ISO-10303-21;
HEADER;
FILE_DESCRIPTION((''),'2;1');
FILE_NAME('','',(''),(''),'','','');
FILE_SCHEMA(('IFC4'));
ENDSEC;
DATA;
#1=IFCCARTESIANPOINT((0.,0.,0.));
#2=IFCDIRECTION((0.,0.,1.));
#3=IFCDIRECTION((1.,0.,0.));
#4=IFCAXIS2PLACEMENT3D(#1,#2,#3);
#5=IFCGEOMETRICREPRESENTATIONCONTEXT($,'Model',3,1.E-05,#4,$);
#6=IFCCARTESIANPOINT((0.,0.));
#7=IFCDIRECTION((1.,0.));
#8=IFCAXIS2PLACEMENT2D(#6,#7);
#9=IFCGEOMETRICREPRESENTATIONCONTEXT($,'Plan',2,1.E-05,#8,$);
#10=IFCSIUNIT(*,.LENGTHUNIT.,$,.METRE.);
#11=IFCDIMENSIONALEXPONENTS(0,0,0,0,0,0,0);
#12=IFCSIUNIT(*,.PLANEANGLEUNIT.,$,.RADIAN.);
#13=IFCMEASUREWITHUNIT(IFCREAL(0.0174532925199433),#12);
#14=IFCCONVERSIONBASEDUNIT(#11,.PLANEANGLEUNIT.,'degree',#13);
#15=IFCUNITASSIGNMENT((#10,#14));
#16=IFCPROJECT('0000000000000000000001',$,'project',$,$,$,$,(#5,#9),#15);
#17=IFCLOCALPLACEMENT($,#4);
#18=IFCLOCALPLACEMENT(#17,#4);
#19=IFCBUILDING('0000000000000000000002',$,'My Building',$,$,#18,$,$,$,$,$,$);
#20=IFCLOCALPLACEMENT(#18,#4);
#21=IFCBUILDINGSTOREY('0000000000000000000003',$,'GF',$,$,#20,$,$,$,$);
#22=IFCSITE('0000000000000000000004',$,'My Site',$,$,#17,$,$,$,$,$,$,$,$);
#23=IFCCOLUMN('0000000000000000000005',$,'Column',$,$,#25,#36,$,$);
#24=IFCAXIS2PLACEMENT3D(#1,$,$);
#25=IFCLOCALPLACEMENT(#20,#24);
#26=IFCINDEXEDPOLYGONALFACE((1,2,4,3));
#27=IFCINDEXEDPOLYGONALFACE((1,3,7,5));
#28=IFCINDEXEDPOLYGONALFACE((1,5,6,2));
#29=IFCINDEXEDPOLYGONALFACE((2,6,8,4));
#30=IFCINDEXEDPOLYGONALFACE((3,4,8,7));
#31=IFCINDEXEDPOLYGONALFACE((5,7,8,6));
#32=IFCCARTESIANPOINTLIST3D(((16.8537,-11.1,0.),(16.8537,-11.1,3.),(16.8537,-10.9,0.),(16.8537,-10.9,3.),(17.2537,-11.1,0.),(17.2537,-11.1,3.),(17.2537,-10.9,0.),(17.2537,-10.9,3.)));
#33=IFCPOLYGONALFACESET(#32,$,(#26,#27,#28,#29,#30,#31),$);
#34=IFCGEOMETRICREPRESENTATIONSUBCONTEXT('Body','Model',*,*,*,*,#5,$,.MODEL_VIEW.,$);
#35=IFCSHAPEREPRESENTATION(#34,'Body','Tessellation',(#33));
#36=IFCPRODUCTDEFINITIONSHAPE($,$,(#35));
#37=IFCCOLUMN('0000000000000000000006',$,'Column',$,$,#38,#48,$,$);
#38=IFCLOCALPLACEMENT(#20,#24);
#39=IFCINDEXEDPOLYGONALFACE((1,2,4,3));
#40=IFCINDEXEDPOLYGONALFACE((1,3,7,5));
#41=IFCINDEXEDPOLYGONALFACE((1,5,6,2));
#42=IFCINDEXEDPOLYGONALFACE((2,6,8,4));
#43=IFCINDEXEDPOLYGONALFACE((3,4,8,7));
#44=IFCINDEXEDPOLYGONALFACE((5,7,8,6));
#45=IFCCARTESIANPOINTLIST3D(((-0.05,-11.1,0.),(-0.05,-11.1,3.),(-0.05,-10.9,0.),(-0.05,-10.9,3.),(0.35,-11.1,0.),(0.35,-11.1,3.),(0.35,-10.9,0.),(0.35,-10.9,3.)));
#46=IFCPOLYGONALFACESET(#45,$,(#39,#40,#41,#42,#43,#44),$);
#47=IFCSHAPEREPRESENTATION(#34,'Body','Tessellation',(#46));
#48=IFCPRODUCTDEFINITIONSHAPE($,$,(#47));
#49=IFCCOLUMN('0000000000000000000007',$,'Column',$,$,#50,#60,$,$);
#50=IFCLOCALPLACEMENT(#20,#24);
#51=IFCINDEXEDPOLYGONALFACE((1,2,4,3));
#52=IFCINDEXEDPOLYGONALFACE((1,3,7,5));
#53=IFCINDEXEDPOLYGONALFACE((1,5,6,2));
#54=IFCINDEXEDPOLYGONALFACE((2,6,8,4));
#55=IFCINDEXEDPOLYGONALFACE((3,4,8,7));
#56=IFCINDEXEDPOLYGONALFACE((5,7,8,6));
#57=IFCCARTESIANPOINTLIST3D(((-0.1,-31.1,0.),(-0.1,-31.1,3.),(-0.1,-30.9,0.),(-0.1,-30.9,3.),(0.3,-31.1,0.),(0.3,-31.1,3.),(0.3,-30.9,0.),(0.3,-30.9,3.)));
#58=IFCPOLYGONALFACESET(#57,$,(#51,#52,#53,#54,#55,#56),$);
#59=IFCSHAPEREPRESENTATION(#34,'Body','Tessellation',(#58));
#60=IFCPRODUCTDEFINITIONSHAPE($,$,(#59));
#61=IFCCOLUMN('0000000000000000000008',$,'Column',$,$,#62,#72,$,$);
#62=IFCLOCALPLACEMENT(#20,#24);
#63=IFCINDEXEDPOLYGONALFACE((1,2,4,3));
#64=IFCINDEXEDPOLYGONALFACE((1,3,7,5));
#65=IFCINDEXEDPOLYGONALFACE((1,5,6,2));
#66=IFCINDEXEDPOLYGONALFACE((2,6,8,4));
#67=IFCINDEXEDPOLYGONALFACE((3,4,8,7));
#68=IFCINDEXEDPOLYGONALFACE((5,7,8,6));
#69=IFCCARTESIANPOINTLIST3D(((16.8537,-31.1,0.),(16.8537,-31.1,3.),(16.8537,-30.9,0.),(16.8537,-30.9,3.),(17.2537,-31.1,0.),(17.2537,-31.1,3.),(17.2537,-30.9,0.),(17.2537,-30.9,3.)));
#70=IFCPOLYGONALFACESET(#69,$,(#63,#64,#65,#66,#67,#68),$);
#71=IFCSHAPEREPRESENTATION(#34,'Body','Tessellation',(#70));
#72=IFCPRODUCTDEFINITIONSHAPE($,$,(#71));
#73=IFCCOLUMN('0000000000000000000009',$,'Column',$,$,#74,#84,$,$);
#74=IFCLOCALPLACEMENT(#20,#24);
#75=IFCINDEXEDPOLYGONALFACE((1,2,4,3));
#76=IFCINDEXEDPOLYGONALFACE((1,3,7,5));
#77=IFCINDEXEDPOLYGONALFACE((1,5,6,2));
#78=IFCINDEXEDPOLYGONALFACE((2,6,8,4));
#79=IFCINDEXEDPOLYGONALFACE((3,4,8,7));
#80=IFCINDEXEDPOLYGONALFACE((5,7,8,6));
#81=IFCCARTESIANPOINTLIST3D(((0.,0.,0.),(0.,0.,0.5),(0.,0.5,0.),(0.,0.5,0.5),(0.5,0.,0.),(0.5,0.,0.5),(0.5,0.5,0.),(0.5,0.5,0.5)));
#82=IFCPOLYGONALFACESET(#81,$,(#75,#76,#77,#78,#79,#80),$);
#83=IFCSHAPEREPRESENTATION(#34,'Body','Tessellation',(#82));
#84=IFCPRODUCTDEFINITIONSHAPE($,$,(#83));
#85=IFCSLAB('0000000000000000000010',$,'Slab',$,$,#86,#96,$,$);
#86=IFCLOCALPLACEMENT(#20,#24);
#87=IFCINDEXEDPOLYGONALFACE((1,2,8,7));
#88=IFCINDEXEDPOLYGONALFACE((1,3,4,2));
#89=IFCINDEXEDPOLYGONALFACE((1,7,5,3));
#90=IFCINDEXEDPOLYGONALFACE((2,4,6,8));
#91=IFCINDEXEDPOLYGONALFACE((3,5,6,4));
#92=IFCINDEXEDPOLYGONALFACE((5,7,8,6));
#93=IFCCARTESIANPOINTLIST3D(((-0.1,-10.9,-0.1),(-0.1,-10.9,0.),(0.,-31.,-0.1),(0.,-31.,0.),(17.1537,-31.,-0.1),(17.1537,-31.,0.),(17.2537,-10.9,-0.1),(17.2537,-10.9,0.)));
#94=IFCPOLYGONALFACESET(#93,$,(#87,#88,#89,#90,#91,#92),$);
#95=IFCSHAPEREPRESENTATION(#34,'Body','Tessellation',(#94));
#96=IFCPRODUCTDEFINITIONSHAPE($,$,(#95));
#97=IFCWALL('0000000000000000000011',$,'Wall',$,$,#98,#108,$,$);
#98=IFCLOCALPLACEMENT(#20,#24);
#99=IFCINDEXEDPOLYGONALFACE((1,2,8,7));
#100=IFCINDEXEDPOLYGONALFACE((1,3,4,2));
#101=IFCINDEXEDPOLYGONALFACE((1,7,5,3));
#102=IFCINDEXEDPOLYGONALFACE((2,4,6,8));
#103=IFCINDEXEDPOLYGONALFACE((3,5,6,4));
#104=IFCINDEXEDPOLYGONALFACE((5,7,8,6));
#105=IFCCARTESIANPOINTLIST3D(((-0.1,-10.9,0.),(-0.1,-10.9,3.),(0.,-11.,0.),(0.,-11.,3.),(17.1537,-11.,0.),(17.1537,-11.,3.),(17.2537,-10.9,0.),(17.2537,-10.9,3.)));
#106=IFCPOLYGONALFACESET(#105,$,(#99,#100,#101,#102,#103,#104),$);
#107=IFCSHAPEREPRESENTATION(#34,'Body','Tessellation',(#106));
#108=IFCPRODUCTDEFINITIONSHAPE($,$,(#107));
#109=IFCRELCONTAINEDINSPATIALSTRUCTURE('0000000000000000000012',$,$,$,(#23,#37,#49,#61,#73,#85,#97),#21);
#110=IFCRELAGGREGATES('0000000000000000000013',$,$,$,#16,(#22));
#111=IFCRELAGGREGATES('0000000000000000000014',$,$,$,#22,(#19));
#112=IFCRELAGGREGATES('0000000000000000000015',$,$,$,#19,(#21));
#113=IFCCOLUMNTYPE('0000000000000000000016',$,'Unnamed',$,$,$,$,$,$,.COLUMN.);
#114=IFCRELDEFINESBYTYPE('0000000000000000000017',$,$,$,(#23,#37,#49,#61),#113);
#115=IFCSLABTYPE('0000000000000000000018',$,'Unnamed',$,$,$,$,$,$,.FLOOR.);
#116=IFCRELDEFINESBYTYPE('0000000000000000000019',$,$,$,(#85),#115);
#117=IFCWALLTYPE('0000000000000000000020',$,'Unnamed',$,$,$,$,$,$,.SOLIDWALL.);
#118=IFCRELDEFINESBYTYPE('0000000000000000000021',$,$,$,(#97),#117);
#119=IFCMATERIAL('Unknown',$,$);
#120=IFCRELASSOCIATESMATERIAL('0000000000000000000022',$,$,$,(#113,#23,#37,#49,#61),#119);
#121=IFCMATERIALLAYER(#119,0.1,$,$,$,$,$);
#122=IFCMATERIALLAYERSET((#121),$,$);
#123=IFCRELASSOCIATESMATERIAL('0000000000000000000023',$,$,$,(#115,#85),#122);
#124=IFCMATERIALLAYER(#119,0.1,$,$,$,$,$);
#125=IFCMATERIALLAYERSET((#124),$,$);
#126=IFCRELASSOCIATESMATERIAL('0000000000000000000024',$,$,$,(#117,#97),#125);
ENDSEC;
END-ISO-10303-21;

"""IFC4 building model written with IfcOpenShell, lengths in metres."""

from ifc_helpers import new_model, entity, si_unit, converted_unit, frame, origin_with_axes, origin_2d_with_axis, place, context, subcontext, project, spatial, line, indexed_curve, rectangle, outline, extrude, material, layer, layer_set, layer_usage, material_profile, profile_set, profile_usage, type_object, element, save


model = new_model("IFC4")

# Units and contexts
model_context = context("Model", 3, precision=1e-05, world=origin_with_axes())
plan_context = context("Plan", 2, precision=1e-05, world=origin_2d_with_axis())
body_context_1 = subcontext(model_context, "Body", "Model", "MODEL_VIEW")
ifc_project = project(units=[si_unit("LENGTHUNIT", "METRE"), converted_unit("PLANEANGLEUNIT", "degree", entity("IfcReal", 0.0174532925199433), si_unit("PLANEANGLEUNIT", "RADIAN"), dimensions=[0, 0, 0, 0, 0, 0, 0])], contexts=[model_context, plan_context])

# Site, building, storey
site_placement = place(None, origin_with_axes())
site = spatial("IfcSite", under=ifc_project, at=site_placement, Name="My Site")
building_placement = place(site_placement, origin_with_axes())
building = spatial("IfcBuilding", under=site, at=building_placement, Name="My Building")
storey_placement = place(building_placement, origin_with_axes())
storey = spatial("IfcBuildingStorey", under=building, at=storey_placement, Name="GF")

# Columns
ifc_material = material(Name="Unknown")
ifc_material_profile = material_profile(ifc_material, rectangle(XDim=0.4, YDim=0.2))
ifc_profile_set = profile_set([ifc_material_profile])
ifc_profile_usage_1 = profile_usage(ifc_profile_set, cardinal=5)
column_type = type_object("IfcColumnType", Name="Unnamed", PredefinedType="COLUMN", material=ifc_profile_set)
column_1_placement = place(storey_placement, frame((17.0537, -11.0, 0.0), z_axis=(0.0, 0.0, 1.0), x_axis=(1.0, 0.0, 0.0)))
element("IfcColumn", 1, at=column_1_placement, inside=storey, type_object=column_type, material=ifc_profile_usage_1, Name="Column", context=body_context_1, shape_type="SweptSolid", body=[
    extrude(rectangle(XDim=0.4, YDim=0.2), origin_with_axes(), (0.0, 0.0, 1.0), 3.0),
])
ifc_profile_usage_2 = profile_usage(ifc_profile_set, cardinal=9)
column_2_placement = place(storey_placement, frame((-0.05, -10.9, 0.0), z_axis=(0.0, 0.0, 1.0), x_axis=(1.0, 0.0, 0.0)))
element("IfcColumn", 2, at=column_2_placement, inside=storey, type_object=column_type, material=ifc_profile_usage_2, Name="Column", context=body_context_1, shape_type="SweptSolid", body=[
    extrude(rectangle(XDim=0.4, YDim=0.2), frame((0.2, -0.1, 0.0), z_axis=(0.0, 0.0, 1.0), x_axis=(1.0, 0.0, 0.0)), (0.0, 0.0, 1.0), 3.0),
])
ifc_profile_usage_3 = profile_usage(ifc_profile_set, cardinal=3)
column_3_placement = place(storey_placement, frame((-0.1, -31.1, 0.0), z_axis=(0.0, 0.0, 1.0), x_axis=(1.0, 0.0, 0.0)))
element("IfcColumn", 3, at=column_3_placement, inside=storey, type_object=column_type, material=ifc_profile_usage_3, Name="Column", context=body_context_1, shape_type="SweptSolid", body=[
    extrude(rectangle(XDim=0.4, YDim=0.2), frame((0.2, 0.1, 0.0), z_axis=(0.0, 0.0, 1.0), x_axis=(1.0, 0.0, 0.0)), (0.0, 0.0, 1.0), 3.0),
])
ifc_profile_usage_4 = profile_usage(ifc_profile_set, cardinal=3)
column_4_placement = place(storey_placement, frame((16.8537, -31.1, 0.0), z_axis=(0.0, 0.0, 1.0), x_axis=(1.0, 0.0, 0.0)))
element("IfcColumn", 4, at=column_4_placement, inside=storey, type_object=column_type, material=ifc_profile_usage_4, Name="Column", context=body_context_1, shape_type="SweptSolid", body=[
    extrude(rectangle(XDim=0.4, YDim=0.2), frame((0.2, 0.1, 0.0), z_axis=(0.0, 0.0, 1.0), x_axis=(1.0, 0.0, 0.0)), (0.0, 0.0, 1.0), 3.0),
])
element("IfcColumn", 5, inside=storey, Name="Column", context=body_context_1, shape_type="SweptSolid", body=[
    extrude(outline(indexed_curve([(0.0, 0.0), (0.5, 0.0), (0.5, 0.5), (0.0, 0.5)], segments=[line(1, 2, 3, 4, 1)])), origin_with_axes(), (0.0, 0.0, 1.0), 0.5),
])

# Slab
ifc_layer_1 = layer(ifc_material, 0.1)
ifc_layer_set_1 = layer_set([ifc_layer_1])
ifc_layer_usage_1 = layer_usage(ifc_layer_set_1, "AXIS3", "POSITIVE", -0.1)
slab_type = type_object("IfcSlabType", Name="Unnamed", PredefinedType="FLOOR", material=ifc_layer_set_1)
slab_placement = place(storey_placement, frame((-0.1, -10.9, 0.0), z_axis=(0.0, 0.0, 1.0), x_axis=(1.0, 0.0, 0.0)))
element("IfcSlab", 6, at=slab_placement, inside=storey, type_object=slab_type, material=ifc_layer_usage_1, Name="Slab", context=body_context_1, shape_type="SweptSolid", body=[
    extrude(outline(indexed_curve([(0.0, 0.0), (17.3537, 0.0), (17.2537, -20.1), (0.1, -20.1), (0.0, 0.0)])), frame((0.0, 0.0, -0.1), z_axis=(0.0, 0.0, 1.0), x_axis=(1.0, 0.0, 0.0)), (0.0, 0.0, 1.0), 0.1),
])

# Wall
ifc_layer_2 = layer(ifc_material, 0.1)
ifc_layer_set_2 = layer_set([ifc_layer_2])
ifc_layer_usage_2 = layer_usage(ifc_layer_set_2, "AXIS2", "POSITIVE", 0.0)
wall_type = type_object("IfcWallType", Name="Unnamed", PredefinedType="SOLIDWALL", material=ifc_layer_set_2)
wall_1_placement = place(storey_placement, frame((0.0, -11.0, 0.0), z_axis=(0.0, 0.0, 1.0), x_axis=(1.0, 0.0, 0.0)))
element("IfcWall", 7, at=wall_1_placement, inside=storey, type_object=wall_type, material=ifc_layer_usage_2, Name="Wall", context=body_context_1, shape_type="SweptSolid", body=[
    extrude(outline(indexed_curve([(0.0, 0.0), (-0.1, 0.1), (17.2537, 0.1), (17.1537, 0.0)], segments=[line(1, 2, 3, 4, 1)])), origin_with_axes(), (0.0, 0.0, 1.0), 3.0),
])

save(model, "model.ifc")
